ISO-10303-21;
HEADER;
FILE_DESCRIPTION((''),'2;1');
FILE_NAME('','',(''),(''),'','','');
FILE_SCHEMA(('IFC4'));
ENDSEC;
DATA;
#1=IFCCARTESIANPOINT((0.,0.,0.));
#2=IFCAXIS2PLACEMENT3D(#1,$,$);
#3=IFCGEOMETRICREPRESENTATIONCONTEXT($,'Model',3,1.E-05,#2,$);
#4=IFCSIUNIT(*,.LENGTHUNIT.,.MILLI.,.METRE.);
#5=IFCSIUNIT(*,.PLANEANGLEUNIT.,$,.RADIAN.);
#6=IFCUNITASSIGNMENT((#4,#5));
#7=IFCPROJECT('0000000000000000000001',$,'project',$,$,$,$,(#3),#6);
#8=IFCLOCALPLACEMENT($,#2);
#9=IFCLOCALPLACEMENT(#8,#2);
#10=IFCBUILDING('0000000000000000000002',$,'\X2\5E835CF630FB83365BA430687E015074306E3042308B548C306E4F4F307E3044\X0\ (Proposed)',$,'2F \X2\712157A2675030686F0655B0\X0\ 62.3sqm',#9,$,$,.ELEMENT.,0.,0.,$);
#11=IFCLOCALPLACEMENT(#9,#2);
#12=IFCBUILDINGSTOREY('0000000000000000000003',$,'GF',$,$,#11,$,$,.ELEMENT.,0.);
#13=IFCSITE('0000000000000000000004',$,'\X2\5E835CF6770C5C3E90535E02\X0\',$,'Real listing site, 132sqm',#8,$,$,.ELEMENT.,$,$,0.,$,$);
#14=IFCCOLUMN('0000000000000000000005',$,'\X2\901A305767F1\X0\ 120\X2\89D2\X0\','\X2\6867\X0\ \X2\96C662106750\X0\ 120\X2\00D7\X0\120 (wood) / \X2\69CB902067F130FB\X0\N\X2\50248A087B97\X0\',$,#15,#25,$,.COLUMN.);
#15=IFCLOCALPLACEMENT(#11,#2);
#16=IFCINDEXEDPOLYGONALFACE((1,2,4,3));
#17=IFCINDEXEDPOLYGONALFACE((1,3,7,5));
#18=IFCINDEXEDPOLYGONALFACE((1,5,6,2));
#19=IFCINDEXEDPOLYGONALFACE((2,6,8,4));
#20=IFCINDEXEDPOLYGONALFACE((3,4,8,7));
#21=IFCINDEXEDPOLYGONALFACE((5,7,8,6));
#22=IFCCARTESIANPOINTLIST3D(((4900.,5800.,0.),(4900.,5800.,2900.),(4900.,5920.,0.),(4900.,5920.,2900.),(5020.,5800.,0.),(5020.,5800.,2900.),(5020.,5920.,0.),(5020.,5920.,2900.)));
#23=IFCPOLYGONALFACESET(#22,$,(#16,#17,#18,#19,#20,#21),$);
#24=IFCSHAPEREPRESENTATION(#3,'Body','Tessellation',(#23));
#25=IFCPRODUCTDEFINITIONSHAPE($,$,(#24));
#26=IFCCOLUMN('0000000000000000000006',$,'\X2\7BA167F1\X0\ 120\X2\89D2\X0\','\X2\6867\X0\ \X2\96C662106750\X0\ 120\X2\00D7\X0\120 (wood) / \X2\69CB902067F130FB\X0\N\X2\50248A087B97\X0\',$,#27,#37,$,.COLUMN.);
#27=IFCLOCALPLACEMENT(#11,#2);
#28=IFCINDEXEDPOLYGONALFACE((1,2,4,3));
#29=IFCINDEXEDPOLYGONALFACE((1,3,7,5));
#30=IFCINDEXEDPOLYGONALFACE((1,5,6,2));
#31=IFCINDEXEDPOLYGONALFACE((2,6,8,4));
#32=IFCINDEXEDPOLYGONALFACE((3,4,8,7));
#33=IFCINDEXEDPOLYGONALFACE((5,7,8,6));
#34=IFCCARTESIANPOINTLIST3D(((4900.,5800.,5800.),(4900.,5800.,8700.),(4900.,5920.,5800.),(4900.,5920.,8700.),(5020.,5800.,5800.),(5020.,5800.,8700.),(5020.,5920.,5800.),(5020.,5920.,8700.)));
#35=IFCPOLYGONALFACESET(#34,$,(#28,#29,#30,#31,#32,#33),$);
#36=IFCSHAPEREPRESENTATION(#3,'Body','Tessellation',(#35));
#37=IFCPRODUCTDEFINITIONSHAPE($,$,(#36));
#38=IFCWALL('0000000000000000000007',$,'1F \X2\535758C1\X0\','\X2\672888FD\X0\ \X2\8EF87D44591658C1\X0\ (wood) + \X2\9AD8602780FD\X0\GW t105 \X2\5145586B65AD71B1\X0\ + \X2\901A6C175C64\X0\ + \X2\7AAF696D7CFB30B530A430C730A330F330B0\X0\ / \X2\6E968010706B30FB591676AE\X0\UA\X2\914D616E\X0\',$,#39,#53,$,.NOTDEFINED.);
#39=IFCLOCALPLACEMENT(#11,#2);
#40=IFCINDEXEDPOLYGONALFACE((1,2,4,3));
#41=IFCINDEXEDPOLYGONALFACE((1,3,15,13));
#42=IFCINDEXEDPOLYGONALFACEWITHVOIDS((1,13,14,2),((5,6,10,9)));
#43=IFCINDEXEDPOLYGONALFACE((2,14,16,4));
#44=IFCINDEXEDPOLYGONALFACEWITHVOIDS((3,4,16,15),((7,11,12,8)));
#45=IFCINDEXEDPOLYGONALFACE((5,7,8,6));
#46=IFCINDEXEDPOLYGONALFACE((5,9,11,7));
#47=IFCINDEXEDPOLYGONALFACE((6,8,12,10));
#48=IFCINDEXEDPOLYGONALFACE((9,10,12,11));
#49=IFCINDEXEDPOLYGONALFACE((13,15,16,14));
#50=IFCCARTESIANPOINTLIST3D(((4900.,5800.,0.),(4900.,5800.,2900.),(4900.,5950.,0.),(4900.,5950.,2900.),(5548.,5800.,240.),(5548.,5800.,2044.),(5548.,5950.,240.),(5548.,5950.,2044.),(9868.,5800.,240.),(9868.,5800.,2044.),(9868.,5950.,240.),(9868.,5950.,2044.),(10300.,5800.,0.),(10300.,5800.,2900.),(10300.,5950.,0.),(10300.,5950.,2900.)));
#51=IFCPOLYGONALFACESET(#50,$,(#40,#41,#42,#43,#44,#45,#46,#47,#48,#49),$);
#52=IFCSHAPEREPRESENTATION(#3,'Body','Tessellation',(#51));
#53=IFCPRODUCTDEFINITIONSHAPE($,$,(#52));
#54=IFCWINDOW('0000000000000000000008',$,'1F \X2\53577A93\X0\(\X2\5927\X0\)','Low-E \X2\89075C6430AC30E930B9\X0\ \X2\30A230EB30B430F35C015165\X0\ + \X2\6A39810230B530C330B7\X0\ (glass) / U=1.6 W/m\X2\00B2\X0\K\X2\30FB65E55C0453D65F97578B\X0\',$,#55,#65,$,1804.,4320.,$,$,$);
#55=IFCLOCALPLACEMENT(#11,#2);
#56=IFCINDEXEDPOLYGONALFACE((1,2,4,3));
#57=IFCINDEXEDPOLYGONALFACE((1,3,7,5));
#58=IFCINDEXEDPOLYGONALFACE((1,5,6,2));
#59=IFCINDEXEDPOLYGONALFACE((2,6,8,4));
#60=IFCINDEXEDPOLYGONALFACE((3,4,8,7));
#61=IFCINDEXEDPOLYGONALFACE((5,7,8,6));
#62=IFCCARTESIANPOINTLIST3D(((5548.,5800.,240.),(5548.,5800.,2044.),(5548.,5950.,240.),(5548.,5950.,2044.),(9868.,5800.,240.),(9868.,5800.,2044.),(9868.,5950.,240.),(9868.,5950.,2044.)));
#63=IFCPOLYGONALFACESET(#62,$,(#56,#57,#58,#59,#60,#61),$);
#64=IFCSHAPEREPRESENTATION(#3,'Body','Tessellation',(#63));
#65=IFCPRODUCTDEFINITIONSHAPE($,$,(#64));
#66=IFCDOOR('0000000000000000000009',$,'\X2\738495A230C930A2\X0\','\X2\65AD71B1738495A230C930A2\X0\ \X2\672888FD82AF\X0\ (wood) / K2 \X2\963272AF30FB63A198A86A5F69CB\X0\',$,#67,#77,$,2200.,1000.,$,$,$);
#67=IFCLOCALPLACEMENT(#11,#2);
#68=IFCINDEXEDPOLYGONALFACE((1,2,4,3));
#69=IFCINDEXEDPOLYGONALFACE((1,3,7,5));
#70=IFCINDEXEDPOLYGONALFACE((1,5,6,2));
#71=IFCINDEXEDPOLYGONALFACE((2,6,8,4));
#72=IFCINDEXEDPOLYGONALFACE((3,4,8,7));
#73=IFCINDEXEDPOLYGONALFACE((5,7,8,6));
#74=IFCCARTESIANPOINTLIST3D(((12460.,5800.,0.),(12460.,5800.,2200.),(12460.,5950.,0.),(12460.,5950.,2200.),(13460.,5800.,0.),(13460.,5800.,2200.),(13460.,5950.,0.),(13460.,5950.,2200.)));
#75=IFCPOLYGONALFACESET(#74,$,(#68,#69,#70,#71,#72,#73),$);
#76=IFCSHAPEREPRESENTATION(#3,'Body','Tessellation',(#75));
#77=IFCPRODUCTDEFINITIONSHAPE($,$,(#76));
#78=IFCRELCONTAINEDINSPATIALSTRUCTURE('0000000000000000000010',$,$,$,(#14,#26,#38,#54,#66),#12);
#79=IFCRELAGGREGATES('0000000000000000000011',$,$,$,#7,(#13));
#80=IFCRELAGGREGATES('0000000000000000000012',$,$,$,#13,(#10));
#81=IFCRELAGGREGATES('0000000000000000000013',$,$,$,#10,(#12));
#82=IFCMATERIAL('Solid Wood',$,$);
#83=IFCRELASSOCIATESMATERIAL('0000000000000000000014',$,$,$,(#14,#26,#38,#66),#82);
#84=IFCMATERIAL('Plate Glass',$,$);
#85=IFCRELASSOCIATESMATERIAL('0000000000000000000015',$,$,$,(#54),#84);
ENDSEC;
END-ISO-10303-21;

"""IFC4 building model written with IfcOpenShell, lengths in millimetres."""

from ifc_helpers import new_model, si_unit, frame, frame_2d, origin, place, context, project, spatial, rectangle, extrude, material, element, fill, save


model = new_model("IFC4")

# Units and contexts
model_context = context("Model", 3, precision=1e-05, world=origin())
ifc_project = project(units=[si_unit("LENGTHUNIT", "METRE", prefix="MILLI"), si_unit("PLANEANGLEUNIT", "RADIAN")], contexts=[model_context])

# Site, building, storey
site_placement = place(None, origin())
site = spatial("IfcSite", under=ifc_project, at=site_placement, Name="広島県尾道市", ObjectType="Real listing site, 132sqm", CompositionType="ELEMENT", RefElevation=0.0)
building_placement = place(site_placement, origin())
building = spatial("IfcBuilding", under=site, at=building_placement, Name="広島・茶室と縁側のある和の住まい (Proposed)", ObjectType="2F 無垢材と漆喰 62.3sqm", CompositionType="ELEMENT", ElevationOfRefHeight=0.0, ElevationOfTerrain=0.0)
storey_placement = place(building_placement, origin())
storey = spatial("IfcBuildingStorey", under=building, at=storey_placement, Name="GF", CompositionType="ELEMENT", Elevation=0.0)

# Columns
ifc_material_1 = material(Name="Solid Wood")
column_1_placement = place(storey_placement, frame((2450.0, 2900.0, 0.0)))
element("IfcColumn", 1, at=column_1_placement, inside=storey, material=ifc_material_1, Name="通し柱 120角", Description="桧 集成材 120×120 (wood) / 構造柱・N値計算", PredefinedType="COLUMN", context=model_context, shape_type="SweptSolid", body=[
    extrude(rectangle(XDim=120.0, YDim=120.0, at=frame_2d((60.0, 60.0))), frame((2450.0, 2900.0, 0.0)), (0.0, 0.0, 1.0), 2900.0),
])
column_2_placement = place(storey_placement, frame((2450.0, 2900.0, 2900.0)))
element("IfcColumn", 2, at=column_2_placement, inside=storey, material=ifc_material_1, Name="管柱 120角", Description="桧 集成材 120×120 (wood) / 構造柱・N値計算", PredefinedType="COLUMN", context=model_context, shape_type="SweptSolid", body=[
    extrude(rectangle(XDim=120.0, YDim=120.0, at=frame_2d((60.0, 60.0))), frame((2450.0, 2900.0, 2900.0)), (0.0, 0.0, 1.0), 2900.0),
])

# Wall, openings, window, door
wall_1_placement = place(storey_placement, frame((2450.0, 2900.0, 0.0)))
wall_1 = element("IfcWall", 3, at=wall_1_placement, inside=storey, material=ifc_material_1, Name="1F 南壁", Description="木製 軸組外壁 (wood) + 高性能GW t105 充填断熱 + 通気層 + 窯業系サイディング / 準耐火・外皮UA配慮", PredefinedType="NOTDEFINED", context=model_context, shape_type="SweptSolid", body=[
    extrude(rectangle(XDim=5400.0, YDim=150.0, at=frame_2d((2700.0, 75.0))), frame((2450.0, 2900.0, 0.0)), (0.0, 0.0, 1.0), 2900.0),
])
opening_1_placement = place(storey_placement, frame((2774.0, 2900.0, 120.0)))
opening_1 = element("IfcOpeningElement", 4, at=opening_1_placement, cuts=wall_1, PredefinedType="NOTDEFINED", context=model_context, shape_type="SweptSolid", body=[
    extrude(rectangle(XDim=4320.0, YDim=150.0, at=frame_2d((2160.0, 75.0))), frame((2774.0, 2900.0, 120.0)), (0.0, 0.0, 1.0), 1804.0),
])
opening_2_placement = place(storey_placement, frame((6230.0, 2900.0, 0.0)))
opening_2 = element("IfcOpeningElement", 5, at=opening_2_placement, cuts=wall_1, PredefinedType="NOTDEFINED", context=model_context, shape_type="SweptSolid", body=[
    extrude(rectangle(XDim=1000.0, YDim=150.0, at=frame_2d((500.0, 75.0))), frame((6230.0, 2900.0, 0.0)), (0.0, 0.0, 1.0), 2200.0),
])
ifc_material_2 = material(Name="Plate Glass")
window_1_placement = place(storey_placement, frame((2774.0, 2900.0, 120.0)))
window_1 = element("IfcWindow", 6, at=window_1_placement, inside=storey, material=ifc_material_2, Name="1F 南窓(大)", Description="Low-E 複層ガラス アルゴン封入 + 樹脂サッシ (glass) / U=1.6 W/m²K・日射取得型", OverallHeight=1804.0, OverallWidth=4320.0, context=model_context, shape_type="SweptSolid", body=[
    extrude(rectangle(XDim=4320.0, YDim=150.0, at=frame_2d((2160.0, 75.0))), frame((2774.0, 2900.0, 120.0)), (0.0, 0.0, 1.0), 1804.0),
])
fill(opening_1, window_1)
door_placement = place(storey_placement, frame((6230.0, 2900.0, 0.0)))
door = element("IfcDoor", 7, at=door_placement, inside=storey, material=ifc_material_1, Name="玄関ドア", Description="断熱玄関ドア 木製芯 (wood) / K2 防犯・採風機構", OverallHeight=2200.0, OverallWidth=1000.0, context=model_context, shape_type="SweptSolid", body=[
    extrude(rectangle(XDim=1000.0, YDim=150.0, at=frame_2d((500.0, 75.0))), frame((6230.0, 2900.0, 0.0)), (0.0, 0.0, 1.0), 2200.0),
])
fill(opening_2, door)

save(model, "model.ifc")
